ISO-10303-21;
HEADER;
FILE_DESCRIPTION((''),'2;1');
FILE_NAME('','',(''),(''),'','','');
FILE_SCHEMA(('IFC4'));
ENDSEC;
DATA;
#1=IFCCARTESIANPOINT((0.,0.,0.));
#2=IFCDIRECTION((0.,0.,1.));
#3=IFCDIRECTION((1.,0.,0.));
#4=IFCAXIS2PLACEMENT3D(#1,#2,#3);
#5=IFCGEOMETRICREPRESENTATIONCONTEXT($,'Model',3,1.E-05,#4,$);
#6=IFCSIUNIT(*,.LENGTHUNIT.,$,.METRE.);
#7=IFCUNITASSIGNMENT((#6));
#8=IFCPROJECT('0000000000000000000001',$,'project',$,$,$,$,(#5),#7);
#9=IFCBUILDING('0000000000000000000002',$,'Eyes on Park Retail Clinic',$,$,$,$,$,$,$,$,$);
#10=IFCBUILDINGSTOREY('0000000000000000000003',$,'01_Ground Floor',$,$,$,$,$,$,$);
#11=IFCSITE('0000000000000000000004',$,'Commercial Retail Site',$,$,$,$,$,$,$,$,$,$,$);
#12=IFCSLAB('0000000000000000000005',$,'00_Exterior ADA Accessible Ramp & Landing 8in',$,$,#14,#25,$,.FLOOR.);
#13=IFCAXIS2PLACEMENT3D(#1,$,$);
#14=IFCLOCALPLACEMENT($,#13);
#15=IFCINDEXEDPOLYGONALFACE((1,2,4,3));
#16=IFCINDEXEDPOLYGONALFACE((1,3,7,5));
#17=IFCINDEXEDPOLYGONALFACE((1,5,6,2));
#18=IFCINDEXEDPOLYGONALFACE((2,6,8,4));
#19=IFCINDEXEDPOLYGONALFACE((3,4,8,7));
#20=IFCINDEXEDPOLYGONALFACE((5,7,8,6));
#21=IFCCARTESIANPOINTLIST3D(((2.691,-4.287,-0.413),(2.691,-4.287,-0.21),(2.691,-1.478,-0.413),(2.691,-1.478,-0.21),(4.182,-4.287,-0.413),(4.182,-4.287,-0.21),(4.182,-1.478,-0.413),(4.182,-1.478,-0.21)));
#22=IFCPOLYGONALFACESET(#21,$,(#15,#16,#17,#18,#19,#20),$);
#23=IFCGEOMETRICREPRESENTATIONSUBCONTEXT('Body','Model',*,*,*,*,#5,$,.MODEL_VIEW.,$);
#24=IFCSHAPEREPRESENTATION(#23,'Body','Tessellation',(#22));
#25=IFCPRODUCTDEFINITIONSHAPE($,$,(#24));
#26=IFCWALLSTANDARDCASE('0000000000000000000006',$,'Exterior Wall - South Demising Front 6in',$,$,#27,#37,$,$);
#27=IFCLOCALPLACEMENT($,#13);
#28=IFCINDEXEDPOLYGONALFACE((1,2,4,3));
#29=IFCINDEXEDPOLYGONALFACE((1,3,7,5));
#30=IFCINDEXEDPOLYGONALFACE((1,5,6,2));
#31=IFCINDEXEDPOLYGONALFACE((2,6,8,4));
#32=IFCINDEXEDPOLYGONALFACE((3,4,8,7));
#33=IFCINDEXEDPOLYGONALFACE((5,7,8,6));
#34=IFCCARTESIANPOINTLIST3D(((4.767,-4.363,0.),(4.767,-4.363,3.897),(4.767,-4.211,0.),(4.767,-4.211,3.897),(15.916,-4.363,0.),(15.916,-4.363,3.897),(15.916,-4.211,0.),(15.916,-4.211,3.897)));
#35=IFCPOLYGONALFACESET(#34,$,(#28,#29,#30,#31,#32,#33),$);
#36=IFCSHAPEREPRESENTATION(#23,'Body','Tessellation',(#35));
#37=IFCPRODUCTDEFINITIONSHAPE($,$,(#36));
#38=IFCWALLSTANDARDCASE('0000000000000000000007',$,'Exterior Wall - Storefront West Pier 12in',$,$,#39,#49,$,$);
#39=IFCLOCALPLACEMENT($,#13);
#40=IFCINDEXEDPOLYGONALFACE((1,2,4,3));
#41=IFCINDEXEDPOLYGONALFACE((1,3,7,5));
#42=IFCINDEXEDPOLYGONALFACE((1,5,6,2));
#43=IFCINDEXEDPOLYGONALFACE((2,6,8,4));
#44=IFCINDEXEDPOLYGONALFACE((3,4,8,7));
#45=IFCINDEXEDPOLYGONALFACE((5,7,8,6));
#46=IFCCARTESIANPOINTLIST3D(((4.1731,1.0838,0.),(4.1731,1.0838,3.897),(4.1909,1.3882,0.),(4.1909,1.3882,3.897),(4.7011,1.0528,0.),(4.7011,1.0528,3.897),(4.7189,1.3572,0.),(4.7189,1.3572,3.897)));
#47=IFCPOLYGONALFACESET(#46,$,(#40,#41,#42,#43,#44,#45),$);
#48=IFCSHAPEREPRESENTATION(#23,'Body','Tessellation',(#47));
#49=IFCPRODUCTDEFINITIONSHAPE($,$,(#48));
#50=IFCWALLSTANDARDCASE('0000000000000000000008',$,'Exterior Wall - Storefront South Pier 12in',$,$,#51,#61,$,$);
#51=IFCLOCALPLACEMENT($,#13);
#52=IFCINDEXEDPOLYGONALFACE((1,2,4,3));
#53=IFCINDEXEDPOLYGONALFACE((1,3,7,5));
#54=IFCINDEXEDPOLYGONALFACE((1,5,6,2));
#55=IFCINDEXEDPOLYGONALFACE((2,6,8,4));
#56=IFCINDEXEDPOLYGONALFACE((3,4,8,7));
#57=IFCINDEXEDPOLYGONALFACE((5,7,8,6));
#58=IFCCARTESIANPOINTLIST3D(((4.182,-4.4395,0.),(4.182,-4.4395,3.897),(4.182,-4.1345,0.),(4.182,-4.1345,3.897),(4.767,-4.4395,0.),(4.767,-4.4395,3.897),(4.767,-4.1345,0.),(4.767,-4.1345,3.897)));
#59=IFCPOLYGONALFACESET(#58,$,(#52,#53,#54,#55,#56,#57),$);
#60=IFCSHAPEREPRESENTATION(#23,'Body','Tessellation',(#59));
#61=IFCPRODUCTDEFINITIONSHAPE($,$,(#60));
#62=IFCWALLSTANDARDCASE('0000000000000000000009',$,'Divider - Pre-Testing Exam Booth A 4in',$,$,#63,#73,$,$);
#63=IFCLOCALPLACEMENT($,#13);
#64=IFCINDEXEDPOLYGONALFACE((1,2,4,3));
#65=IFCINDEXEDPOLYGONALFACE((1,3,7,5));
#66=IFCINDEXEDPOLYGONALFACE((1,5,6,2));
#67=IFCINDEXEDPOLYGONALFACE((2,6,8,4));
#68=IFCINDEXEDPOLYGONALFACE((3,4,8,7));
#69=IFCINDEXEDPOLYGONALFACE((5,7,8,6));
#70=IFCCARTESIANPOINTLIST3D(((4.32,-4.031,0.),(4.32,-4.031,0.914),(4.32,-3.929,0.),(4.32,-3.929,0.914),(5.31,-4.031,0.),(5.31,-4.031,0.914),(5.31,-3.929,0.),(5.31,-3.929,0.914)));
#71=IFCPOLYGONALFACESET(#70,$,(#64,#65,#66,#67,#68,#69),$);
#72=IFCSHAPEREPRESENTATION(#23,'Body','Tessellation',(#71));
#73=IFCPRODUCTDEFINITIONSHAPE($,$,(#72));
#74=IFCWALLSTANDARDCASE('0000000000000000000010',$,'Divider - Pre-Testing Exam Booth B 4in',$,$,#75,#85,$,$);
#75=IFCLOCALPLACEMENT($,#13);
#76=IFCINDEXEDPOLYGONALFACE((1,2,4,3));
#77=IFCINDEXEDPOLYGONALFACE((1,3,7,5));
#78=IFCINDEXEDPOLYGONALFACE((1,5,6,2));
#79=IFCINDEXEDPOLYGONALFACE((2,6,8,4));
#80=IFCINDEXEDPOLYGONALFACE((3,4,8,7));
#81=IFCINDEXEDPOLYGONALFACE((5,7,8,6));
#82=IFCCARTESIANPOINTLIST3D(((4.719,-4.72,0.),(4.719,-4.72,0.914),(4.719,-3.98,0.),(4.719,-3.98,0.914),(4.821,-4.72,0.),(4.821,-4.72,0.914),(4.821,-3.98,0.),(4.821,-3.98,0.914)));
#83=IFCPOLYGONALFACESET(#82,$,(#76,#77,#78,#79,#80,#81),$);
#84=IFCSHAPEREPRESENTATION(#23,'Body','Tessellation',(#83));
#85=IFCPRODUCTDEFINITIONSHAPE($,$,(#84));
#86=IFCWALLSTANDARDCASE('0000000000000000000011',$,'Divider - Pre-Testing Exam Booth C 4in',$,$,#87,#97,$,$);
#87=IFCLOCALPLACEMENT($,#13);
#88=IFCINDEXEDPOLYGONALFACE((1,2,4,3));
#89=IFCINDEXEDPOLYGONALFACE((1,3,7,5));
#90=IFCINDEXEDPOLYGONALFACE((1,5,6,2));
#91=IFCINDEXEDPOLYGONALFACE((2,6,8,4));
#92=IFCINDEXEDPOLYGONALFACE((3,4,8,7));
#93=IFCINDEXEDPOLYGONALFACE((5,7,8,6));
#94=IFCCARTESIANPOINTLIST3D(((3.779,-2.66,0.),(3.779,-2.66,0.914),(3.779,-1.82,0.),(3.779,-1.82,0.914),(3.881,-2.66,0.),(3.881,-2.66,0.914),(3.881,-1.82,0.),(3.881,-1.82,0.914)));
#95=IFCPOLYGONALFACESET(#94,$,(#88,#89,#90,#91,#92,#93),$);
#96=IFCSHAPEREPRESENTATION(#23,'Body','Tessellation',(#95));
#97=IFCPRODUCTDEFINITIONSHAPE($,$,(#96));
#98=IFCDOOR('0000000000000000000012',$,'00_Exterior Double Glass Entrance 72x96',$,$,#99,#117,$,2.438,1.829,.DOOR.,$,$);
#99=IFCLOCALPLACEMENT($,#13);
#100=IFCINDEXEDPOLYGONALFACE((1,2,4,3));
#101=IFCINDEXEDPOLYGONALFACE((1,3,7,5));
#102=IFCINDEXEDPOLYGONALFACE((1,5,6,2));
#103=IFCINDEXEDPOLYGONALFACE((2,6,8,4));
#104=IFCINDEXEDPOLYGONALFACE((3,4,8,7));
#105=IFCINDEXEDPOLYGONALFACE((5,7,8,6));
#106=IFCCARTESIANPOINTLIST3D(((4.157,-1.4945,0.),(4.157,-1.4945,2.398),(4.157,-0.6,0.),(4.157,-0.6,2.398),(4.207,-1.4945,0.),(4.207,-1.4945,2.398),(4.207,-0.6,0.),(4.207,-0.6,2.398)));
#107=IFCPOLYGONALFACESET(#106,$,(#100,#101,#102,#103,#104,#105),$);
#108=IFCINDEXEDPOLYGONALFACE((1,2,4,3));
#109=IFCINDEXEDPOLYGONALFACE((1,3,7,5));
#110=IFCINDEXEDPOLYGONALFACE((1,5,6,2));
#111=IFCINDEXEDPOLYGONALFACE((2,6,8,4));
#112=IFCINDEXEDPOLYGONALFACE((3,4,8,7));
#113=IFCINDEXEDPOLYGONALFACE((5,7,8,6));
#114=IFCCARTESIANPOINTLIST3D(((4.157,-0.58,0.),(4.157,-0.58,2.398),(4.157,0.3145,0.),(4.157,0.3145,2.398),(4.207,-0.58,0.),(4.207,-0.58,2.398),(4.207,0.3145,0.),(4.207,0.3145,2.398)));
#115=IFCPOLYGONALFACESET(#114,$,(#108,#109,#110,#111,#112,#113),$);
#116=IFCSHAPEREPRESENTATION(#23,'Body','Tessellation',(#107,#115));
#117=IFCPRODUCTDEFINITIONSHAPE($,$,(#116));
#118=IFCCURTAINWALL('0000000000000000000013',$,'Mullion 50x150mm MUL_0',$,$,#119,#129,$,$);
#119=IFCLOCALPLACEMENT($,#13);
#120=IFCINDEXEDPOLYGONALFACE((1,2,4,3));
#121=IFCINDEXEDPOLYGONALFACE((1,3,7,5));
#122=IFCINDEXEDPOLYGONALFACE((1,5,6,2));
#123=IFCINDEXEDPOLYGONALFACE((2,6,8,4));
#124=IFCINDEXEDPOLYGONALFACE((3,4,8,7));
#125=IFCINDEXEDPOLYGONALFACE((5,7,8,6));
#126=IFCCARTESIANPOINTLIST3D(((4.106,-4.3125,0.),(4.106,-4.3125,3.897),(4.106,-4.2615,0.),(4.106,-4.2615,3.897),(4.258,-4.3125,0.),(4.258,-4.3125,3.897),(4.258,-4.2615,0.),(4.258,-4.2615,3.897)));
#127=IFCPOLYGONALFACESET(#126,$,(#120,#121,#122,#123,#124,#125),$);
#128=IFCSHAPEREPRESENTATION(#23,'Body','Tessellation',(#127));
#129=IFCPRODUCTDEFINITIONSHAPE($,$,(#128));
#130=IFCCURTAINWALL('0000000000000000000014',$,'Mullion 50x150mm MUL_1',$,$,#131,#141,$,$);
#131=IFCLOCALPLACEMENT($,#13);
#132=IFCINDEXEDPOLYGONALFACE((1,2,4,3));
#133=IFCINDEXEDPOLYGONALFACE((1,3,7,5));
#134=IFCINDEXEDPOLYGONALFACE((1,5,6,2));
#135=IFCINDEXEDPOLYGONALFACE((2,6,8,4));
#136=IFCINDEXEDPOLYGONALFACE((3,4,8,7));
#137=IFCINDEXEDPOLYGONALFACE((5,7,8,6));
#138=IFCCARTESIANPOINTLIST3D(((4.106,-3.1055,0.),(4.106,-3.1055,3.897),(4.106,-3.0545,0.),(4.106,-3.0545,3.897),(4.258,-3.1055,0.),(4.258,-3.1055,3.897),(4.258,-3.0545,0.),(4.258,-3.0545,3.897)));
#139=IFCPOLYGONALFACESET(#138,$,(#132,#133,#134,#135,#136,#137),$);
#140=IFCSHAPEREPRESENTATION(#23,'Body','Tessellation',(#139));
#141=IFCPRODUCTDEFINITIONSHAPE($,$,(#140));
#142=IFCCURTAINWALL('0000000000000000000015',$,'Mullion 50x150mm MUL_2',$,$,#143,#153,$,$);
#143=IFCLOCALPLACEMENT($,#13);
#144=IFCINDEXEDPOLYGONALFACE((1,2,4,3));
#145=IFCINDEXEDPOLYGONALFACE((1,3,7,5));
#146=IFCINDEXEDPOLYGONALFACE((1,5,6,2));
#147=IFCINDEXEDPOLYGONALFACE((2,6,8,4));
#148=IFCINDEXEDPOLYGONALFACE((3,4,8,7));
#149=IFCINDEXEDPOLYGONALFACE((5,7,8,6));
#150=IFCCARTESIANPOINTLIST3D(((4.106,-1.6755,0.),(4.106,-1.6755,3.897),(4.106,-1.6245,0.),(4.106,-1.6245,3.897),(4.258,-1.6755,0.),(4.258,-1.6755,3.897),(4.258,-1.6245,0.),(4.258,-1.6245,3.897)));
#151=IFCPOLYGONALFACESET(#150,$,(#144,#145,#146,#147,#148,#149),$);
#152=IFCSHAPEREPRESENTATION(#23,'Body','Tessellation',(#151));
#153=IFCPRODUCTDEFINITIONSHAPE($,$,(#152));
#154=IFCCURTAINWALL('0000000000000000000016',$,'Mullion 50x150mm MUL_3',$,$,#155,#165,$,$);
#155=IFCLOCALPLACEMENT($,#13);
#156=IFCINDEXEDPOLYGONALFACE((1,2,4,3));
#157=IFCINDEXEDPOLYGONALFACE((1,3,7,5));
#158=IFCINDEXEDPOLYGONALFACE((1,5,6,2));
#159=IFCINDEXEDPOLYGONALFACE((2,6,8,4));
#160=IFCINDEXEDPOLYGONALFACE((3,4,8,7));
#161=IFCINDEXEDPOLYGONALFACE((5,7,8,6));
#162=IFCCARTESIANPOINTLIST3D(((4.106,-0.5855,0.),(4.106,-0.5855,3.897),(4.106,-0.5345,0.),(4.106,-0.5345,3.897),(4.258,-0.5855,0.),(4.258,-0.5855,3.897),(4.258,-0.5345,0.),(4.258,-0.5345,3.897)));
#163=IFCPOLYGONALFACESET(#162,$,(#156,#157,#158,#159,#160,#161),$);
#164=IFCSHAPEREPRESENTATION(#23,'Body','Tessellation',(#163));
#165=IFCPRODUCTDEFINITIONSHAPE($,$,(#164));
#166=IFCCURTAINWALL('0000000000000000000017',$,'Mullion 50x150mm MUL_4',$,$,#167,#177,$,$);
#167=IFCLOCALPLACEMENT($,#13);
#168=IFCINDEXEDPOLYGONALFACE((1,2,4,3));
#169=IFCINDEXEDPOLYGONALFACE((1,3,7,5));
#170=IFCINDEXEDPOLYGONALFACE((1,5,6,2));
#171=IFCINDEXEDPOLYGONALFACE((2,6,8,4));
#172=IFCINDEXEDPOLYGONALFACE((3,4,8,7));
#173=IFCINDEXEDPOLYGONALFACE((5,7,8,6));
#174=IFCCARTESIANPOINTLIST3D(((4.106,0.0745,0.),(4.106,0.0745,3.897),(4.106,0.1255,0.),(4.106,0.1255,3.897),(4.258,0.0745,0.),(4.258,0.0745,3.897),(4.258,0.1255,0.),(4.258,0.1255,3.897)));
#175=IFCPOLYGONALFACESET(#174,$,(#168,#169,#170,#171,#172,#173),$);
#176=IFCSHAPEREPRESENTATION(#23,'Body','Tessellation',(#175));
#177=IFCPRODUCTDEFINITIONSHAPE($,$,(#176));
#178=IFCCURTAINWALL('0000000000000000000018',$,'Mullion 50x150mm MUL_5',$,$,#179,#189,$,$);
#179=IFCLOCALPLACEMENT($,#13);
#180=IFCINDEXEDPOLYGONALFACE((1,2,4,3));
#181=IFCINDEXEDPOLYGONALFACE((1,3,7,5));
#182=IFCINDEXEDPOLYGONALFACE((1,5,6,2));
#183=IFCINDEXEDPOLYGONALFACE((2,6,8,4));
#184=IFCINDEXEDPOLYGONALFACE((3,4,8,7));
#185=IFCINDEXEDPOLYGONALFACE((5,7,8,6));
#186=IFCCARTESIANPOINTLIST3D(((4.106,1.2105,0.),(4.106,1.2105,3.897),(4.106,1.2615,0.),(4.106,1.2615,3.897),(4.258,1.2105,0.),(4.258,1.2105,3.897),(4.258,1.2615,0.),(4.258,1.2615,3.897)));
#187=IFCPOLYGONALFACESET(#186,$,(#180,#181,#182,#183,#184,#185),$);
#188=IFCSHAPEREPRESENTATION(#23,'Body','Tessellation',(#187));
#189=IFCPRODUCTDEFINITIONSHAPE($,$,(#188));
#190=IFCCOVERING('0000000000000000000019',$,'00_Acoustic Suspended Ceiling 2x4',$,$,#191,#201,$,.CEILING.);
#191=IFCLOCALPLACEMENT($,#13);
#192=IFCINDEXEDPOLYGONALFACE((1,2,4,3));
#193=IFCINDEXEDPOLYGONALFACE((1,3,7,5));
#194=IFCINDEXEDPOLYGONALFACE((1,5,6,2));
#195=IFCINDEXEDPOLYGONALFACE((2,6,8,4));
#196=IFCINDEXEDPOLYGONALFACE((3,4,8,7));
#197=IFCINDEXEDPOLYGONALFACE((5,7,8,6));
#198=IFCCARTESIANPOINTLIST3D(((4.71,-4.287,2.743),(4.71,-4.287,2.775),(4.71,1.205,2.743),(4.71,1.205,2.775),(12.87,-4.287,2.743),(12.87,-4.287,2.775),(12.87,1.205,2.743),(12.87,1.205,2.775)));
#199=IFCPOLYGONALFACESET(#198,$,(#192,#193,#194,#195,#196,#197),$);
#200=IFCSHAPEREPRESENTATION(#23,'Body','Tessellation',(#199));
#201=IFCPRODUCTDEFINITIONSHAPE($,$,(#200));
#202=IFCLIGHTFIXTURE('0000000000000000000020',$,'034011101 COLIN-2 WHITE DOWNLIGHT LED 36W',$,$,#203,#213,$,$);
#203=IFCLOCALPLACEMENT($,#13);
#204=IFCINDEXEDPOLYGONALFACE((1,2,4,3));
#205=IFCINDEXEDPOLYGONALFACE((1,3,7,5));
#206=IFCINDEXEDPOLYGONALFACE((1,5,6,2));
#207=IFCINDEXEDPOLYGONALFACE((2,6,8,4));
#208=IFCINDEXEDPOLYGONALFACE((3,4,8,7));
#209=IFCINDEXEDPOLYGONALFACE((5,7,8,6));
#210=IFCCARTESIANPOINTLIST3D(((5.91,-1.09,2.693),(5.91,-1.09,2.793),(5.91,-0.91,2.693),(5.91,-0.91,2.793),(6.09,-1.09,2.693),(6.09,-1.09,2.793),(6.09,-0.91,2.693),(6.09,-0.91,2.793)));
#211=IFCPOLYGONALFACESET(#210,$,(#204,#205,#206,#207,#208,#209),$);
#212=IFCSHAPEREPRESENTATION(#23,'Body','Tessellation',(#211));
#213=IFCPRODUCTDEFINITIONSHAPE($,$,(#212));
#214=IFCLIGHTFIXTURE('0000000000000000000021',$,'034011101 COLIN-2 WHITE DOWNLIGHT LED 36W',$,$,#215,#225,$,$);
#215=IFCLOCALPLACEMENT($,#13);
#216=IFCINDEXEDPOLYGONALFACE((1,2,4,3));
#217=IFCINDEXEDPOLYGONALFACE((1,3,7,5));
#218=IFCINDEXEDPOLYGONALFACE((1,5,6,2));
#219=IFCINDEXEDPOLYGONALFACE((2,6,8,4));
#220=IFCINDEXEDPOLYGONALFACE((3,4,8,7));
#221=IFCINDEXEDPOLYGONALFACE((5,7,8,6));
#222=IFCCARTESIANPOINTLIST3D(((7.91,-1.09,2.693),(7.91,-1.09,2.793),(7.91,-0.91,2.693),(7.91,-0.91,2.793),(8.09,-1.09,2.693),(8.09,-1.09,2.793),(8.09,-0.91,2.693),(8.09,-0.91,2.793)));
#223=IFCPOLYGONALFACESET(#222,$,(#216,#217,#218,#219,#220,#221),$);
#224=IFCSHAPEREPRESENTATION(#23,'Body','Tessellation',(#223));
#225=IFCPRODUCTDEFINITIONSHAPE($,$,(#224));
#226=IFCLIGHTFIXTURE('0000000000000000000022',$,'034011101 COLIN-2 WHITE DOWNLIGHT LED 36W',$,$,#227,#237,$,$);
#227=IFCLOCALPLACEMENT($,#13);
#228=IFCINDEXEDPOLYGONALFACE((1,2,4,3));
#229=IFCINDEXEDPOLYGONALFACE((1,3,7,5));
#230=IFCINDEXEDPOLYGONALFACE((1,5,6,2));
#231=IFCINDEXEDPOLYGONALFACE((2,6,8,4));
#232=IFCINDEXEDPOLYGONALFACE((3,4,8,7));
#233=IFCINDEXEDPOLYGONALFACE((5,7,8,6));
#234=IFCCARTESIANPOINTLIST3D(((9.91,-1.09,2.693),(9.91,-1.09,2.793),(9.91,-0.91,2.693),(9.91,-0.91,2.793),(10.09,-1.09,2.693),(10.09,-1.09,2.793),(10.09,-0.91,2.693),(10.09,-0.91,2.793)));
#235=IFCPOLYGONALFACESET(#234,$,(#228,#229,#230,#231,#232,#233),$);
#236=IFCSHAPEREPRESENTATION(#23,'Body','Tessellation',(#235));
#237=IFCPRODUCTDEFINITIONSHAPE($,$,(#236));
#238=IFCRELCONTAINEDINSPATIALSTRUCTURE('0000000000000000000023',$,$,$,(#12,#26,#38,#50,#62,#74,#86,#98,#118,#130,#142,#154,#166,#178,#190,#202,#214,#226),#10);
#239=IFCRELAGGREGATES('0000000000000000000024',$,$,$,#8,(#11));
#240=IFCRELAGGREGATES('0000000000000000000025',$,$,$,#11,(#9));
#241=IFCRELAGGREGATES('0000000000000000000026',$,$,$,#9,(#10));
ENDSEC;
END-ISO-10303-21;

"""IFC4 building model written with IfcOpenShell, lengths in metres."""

from ifc_helpers import new_model, si_unit, frame, origin, origin_with_axes, place, context, subcontext, project, spatial, rectangle, extrude, element, save


model = new_model("IFC4")

# Units and contexts
model_context = context("Model", 3, precision=1e-05, world=origin_with_axes())
body_context = subcontext(model_context, "Body", "Model", "MODEL_VIEW")
ifc_project = project(units=[si_unit("LENGTHUNIT", "METRE")], contexts=[model_context])

# Site, building, storey
site = spatial("IfcSite", under=ifc_project, Name="Commercial Retail Site")
building = spatial("IfcBuilding", under=site, Name="Eyes on Park Retail Clinic")
storey = spatial("IfcBuildingStorey", under=building, Name="01_Ground Floor")

# Slab
slab_placement = place(None, frame((3.4365, -2.8825, -0.413), z_axis=(0.0, 0.0, 1.0), x_axis=(1.0, 0.0, 0.0)))
element("IfcSlab", 1, at=slab_placement, inside=storey, Name="00_Exterior ADA Accessible Ramp & Landing 8in", PredefinedType="FLOOR", context=body_context, shape_type="SweptSolid", body=[
    extrude(rectangle(XDim=1.491, YDim=2.809), origin(), (0.0, 0.0, 1.0), 0.203),
])

# Walls
wall_1_placement = place(None, frame((10.3415, -4.287, 0.0), z_axis=(0.0, 0.0, 1.0), x_axis=(1.0, 0.0, 0.0)))
element("IfcWallStandardCase", 2, at=wall_1_placement, inside=storey, Name="Exterior Wall - South Demising Front 6in", context=body_context, shape_type="SweptSolid", body=[
    extrude(rectangle(XDim=11.149, YDim=0.152), origin(), (0.0, 0.0, 1.0), 3.897),
])
wall_2_placement = place(None, frame((4.446, 1.2205, 0.0), z_axis=(0.0, 0.0, 1.0), x_axis=(-0.998281, 0.058611, 0.0)))
element("IfcWallStandardCase", 3, at=wall_2_placement, inside=storey, Name="Exterior Wall - Storefront West Pier 12in", context=body_context, shape_type="SweptSolid", body=[
    extrude(rectangle(XDim=0.5289, YDim=0.305), origin(), (0.0, 0.0, 1.0), 3.897),
])
wall_3_placement = place(None, frame((4.4745, -4.287, 0.0), z_axis=(0.0, 0.0, 1.0), x_axis=(-1.0, 0.0, 0.0)))
element("IfcWallStandardCase", 4, at=wall_3_placement, inside=storey, Name="Exterior Wall - Storefront South Pier 12in", context=body_context, shape_type="SweptSolid", body=[
    extrude(rectangle(XDim=0.585, YDim=0.305), origin(), (0.0, 0.0, 1.0), 3.897),
])
wall_4_placement = place(None, frame((4.815, -3.98, 0.0), z_axis=(0.0, 0.0, 1.0), x_axis=(1.0, 0.0, 0.0)))
element("IfcWallStandardCase", 5, at=wall_4_placement, inside=storey, Name="Divider - Pre-Testing Exam Booth A 4in", context=body_context, shape_type="SweptSolid", body=[
    extrude(rectangle(XDim=0.99, YDim=0.102), origin(), (0.0, 0.0, 1.0), 0.914),
])
wall_5_placement = place(None, frame((4.77, -4.35, 0.0), z_axis=(0.0, 0.0, 1.0), x_axis=(0.0, -1.0, 0.0)))
element("IfcWallStandardCase", 6, at=wall_5_placement, inside=storey, Name="Divider - Pre-Testing Exam Booth B 4in", context=body_context, shape_type="SweptSolid", body=[
    extrude(rectangle(XDim=0.74, YDim=0.102), origin(), (0.0, 0.0, 1.0), 0.914),
])
wall_6_placement = place(None, frame((3.83, -2.24, 0.0), z_axis=(0.0, 0.0, 1.0), x_axis=(0.0, -1.0, 0.0)))
element("IfcWallStandardCase", 7, at=wall_6_placement, inside=storey, Name="Divider - Pre-Testing Exam Booth C 4in", context=body_context, shape_type="SweptSolid", body=[
    extrude(rectangle(XDim=0.84, YDim=0.102), origin(), (0.0, 0.0, 1.0), 0.914),
])

# Door
door_placement = place(None, frame((4.182, -0.59, 0.0), z_axis=(0.0, 0.0, 1.0), x_axis=(0.0, 1.0, 0.0)))
element("IfcDoor", 8, at=door_placement, inside=storey, Name="00_Exterior Double Glass Entrance 72x96", OverallHeight=2.438, OverallWidth=1.829, PredefinedType="DOOR", context=body_context, shape_type="SweptSolid", body=[
    extrude(rectangle(XDim=0.8945, YDim=0.05), frame((-0.4572, 0.0, 0.0)), (0.0, 0.0, 1.0), 2.398),
    extrude(rectangle(XDim=0.8945, YDim=0.05), frame((0.4572, 0.0, 0.0)), (0.0, 0.0, 1.0), 2.398),
])

# Curtain walls
for number, where, z_axis, x_axis, name in (
    (9, (4.182, -4.287, 0.0), (0.0, 0.0, 1.0), (1.0, 0.0, 0.0), "Mullion 50x150mm MUL_0"),
    (10, (4.182, -3.08, 0.0), (0.0, 0.0, 1.0), (1.0, 0.0, 0.0), "Mullion 50x150mm MUL_1"),
    (11, (4.182, -1.65, 0.0), (0.0, 0.0, 1.0), (1.0, 0.0, 0.0), "Mullion 50x150mm MUL_2"),
    (12, (4.182, -0.56, 0.0), (0.0, 0.0, 1.0), (1.0, 0.0, 0.0), "Mullion 50x150mm MUL_3"),
    (13, (4.182, 0.1, 0.0), (0.0, 0.0, 1.0), (1.0, 0.0, 0.0), "Mullion 50x150mm MUL_4"),
    (14, (4.182, 1.236, 0.0), (0.0, 0.0, 1.0), (1.0, 0.0, 0.0), "Mullion 50x150mm MUL_5"),
):
    element("IfcCurtainWall", number, at=place(None, frame(where, z_axis=z_axis, x_axis=x_axis)), inside=storey, Name=name, context=body_context, shape_type="SweptSolid", body=[
        extrude(rectangle(XDim=0.152, YDim=0.051), origin(), (0.0, 0.0, 1.0), 3.897),
    ])

# Covering
covering_placement = place(None, frame((8.79, -1.541, 2.743), z_axis=(0.0, 0.0, 1.0), x_axis=(1.0, 0.0, 0.0)))
element("IfcCovering", 15, at=covering_placement, inside=storey, Name="00_Acoustic Suspended Ceiling 2x4", PredefinedType="CEILING", context=body_context, shape_type="SweptSolid", body=[
    extrude(rectangle(XDim=8.16, YDim=5.492), origin(), (0.0, 0.0, 1.0), 0.032),
])

# Light fixtures
for number, where, z_axis, x_axis, name in (
    (16, (6.0, -1.0, 2.693), (0.0, 0.0, 1.0), (1.0, 0.0, 0.0), "034011101 COLIN-2 WHITE DOWNLIGHT LED 36W"),
    (17, (8.0, -1.0, 2.693), (0.0, 0.0, 1.0), (1.0, 0.0, 0.0), "034011101 COLIN-2 WHITE DOWNLIGHT LED 36W"),
    (18, (10.0, -1.0, 2.693), (0.0, 0.0, 1.0), (1.0, 0.0, 0.0), "034011101 COLIN-2 WHITE DOWNLIGHT LED 36W"),
):
    element("IfcLightFixture", number, at=place(None, frame(where, z_axis=z_axis, x_axis=x_axis)), inside=storey, Name=name, context=body_context, shape_type="SweptSolid", body=[
        extrude(rectangle(XDim=0.18, YDim=0.18), origin(), (0.0, 0.0, 1.0), 0.1),
    ])

save(model, "model.ifc")
